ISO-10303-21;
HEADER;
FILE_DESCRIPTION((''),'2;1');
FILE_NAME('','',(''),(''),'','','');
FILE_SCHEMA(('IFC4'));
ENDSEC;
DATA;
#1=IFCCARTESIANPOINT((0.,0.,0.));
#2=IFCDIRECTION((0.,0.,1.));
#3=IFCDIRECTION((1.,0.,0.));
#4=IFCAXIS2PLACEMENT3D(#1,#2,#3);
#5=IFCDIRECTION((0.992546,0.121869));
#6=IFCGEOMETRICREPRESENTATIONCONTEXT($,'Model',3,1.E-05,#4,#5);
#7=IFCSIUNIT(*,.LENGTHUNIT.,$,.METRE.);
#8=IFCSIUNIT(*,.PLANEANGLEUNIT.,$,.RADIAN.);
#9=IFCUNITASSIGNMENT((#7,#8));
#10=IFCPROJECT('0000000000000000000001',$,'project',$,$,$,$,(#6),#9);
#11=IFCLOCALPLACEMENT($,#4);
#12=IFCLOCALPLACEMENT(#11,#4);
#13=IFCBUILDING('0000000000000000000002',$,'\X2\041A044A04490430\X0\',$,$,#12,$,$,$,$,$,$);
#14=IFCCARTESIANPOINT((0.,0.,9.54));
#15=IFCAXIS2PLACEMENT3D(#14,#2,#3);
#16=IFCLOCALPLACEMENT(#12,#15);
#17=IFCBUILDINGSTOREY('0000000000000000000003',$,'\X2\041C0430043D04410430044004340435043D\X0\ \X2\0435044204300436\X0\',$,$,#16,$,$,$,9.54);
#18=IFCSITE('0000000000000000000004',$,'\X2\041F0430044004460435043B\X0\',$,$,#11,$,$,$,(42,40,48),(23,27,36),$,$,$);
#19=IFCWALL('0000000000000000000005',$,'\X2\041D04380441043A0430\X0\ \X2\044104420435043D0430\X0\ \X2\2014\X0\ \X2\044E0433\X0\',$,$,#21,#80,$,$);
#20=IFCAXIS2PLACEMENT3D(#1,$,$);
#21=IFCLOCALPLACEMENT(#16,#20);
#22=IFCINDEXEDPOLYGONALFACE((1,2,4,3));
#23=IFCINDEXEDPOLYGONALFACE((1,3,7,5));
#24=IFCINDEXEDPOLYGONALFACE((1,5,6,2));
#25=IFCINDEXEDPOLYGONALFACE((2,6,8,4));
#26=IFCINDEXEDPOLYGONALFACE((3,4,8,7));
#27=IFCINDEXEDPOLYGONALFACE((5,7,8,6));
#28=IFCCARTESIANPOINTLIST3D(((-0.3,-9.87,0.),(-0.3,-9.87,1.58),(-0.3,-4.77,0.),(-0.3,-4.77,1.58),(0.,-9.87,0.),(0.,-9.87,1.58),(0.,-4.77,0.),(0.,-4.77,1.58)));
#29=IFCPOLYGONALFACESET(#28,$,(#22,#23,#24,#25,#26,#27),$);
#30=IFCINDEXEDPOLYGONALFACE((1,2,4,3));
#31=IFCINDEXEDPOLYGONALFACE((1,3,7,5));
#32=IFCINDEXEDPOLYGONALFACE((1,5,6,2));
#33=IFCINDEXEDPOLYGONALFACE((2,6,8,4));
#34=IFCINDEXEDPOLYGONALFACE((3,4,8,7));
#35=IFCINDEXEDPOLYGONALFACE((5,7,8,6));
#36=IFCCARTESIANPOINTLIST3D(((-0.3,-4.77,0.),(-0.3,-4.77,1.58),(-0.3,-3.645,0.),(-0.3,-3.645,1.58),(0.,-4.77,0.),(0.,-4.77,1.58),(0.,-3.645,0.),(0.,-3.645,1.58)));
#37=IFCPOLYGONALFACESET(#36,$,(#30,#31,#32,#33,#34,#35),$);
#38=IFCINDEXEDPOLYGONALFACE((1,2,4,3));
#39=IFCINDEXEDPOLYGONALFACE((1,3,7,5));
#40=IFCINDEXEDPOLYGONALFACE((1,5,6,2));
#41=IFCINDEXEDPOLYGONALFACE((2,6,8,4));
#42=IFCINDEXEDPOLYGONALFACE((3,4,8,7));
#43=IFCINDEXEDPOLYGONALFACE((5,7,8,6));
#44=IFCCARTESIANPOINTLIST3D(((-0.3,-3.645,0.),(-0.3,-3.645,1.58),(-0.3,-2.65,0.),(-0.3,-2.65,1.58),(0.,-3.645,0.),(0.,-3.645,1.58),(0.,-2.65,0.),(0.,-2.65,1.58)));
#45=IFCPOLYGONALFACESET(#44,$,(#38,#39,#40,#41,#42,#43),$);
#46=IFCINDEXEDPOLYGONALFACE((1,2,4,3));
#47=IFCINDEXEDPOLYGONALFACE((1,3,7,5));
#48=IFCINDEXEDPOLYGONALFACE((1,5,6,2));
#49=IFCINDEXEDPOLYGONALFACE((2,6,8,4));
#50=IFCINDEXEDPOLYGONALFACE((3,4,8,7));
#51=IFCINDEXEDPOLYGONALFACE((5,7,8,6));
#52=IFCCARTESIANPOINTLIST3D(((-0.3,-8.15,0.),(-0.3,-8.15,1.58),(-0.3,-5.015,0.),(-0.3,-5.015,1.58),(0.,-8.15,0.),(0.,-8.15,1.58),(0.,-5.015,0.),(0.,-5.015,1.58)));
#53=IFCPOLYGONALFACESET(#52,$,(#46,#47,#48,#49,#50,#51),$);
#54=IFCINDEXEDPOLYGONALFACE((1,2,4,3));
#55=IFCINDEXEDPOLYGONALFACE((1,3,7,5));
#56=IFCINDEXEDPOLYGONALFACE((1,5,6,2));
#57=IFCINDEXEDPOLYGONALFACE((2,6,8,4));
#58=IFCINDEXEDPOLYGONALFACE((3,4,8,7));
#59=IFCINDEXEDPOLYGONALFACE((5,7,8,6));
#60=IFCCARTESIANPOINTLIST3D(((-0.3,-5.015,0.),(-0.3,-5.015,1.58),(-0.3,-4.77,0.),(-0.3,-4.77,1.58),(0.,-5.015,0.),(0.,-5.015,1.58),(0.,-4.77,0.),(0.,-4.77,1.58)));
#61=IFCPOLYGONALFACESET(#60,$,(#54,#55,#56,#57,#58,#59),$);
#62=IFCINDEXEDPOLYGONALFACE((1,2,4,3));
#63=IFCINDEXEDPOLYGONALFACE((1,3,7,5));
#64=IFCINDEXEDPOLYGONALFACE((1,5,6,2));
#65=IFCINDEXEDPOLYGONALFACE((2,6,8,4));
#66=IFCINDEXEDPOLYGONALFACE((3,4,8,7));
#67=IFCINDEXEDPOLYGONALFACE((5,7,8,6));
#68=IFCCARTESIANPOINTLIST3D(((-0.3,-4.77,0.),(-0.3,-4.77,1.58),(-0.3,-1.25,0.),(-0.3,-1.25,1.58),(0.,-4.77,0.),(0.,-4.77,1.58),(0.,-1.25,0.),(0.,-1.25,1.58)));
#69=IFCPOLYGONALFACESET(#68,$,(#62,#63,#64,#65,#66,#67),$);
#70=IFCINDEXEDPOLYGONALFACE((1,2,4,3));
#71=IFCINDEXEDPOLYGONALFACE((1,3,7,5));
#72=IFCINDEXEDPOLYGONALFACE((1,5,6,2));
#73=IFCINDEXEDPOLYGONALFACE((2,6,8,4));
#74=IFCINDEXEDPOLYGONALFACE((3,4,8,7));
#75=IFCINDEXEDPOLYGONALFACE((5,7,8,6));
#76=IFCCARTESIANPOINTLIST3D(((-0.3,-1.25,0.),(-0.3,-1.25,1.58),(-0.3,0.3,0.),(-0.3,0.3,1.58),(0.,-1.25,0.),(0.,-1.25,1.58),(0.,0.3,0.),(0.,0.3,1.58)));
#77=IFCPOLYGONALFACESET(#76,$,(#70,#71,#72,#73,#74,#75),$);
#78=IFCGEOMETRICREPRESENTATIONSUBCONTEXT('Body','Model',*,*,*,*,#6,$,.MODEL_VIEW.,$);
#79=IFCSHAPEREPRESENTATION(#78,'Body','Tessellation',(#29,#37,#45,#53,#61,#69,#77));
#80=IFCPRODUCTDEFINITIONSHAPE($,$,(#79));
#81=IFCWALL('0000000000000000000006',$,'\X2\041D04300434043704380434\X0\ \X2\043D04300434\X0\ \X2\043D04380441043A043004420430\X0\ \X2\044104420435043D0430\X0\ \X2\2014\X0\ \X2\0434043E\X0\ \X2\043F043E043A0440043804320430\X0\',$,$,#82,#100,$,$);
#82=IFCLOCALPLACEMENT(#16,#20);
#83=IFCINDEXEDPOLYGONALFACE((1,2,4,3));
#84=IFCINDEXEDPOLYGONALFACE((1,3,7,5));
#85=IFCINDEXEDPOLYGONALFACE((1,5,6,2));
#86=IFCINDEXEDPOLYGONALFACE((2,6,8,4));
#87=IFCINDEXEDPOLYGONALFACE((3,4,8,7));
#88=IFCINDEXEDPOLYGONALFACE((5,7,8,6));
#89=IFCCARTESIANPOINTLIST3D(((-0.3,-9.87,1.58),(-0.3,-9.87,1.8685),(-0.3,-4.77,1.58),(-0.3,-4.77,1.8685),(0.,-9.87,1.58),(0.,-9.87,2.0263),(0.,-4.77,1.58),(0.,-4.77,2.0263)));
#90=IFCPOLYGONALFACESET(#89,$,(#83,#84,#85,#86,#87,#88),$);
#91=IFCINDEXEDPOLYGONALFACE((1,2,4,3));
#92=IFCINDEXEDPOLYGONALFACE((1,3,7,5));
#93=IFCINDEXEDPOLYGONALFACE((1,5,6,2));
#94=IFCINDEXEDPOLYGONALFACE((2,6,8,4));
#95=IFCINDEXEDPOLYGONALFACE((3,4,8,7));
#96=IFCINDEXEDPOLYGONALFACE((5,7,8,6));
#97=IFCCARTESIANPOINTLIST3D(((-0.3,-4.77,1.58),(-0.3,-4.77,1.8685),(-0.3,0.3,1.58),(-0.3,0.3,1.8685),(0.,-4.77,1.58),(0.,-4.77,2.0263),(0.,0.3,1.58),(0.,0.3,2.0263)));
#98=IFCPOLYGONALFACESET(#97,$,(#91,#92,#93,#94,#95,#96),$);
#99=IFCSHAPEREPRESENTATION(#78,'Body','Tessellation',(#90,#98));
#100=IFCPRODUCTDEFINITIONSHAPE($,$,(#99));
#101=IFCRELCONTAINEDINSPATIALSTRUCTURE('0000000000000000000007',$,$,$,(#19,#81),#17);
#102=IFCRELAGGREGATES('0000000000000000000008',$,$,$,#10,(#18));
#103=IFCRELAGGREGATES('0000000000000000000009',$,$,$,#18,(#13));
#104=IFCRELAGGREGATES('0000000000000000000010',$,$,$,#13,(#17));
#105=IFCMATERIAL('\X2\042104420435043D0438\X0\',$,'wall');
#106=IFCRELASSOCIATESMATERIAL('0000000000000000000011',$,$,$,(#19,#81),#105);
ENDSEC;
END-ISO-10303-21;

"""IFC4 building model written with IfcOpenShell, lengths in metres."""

from ifc_helpers import new_model, si_unit, direction, frame, origin_with_axes, place, context, subcontext, project, spatial, polyline, outline, extrude, material, element, save


model = new_model("IFC4")

# Units and contexts
model_context = context("Model", 3, precision=1e-05, world=origin_with_axes(), true_north=direction((0.992546, 0.121869)))
body_context = subcontext(model_context, "Body", "Model", "MODEL_VIEW")
ifc_project = project(units=[si_unit("LENGTHUNIT", "METRE"), si_unit("PLANEANGLEUNIT", "RADIAN")], contexts=[model_context])

# Site, building, storey
site_placement = place(None, origin_with_axes())
site = spatial("IfcSite", under=ifc_project, at=site_placement, Name="Парцел", RefLatitude=(42, 40, 48), RefLongitude=(23, 27, 36))
building_placement = place(site_placement, origin_with_axes())
building = spatial("IfcBuilding", under=site, at=building_placement, Name="Къща")
storey_placement = place(building_placement, frame((0.0, 0.0, 9.54), z_axis=(0.0, 0.0, 1.0), x_axis=(1.0, 0.0, 0.0)))
storey = spatial("IfcBuildingStorey", under=building, at=storey_placement, Name="Мансарден етаж", Elevation=9.54)

# Walls
ifc_material_1 = material(Name="Стени", Category="wall")
wall_1_placement = place(storey_placement, origin_with_axes())
element("IfcWall", 1, at=wall_1_placement, inside=storey, material=ifc_material_1, Name="Ниска стена — юг", context=body_context, shape_type="SweptSolid", body=[
    extrude(outline(polyline([(-0.3, 0.0), (0.0, 0.0), (0.0, -1.58), (-0.3, -1.58), (-0.3, 0.0)])), frame((0.0, -9.87, 0.0), z_axis=(0.0, 1.0, 0.0), x_axis=(1.0, 0.0, 0.0)), (0.0, 0.0, 1.0), 5.1),
    extrude(outline(polyline([(-0.3, 0.0), (0.0, 0.0), (0.0, -1.58), (-0.3, -1.58), (-0.3, 0.0)])), frame((0.0, -4.77, 0.0), z_axis=(0.0, 1.0, 0.0), x_axis=(1.0, 0.0, 0.0)), (0.0, 0.0, 1.0), 1.125),
    extrude(outline(polyline([(-0.3, 0.0), (0.0, 0.0), (0.0, -1.58), (-0.3, -1.58), (-0.3, 0.0)])), frame((0.0, -3.645, 0.0), z_axis=(0.0, 1.0, 0.0), x_axis=(1.0, 0.0, 0.0)), (0.0, 0.0, 1.0), 0.995),
    extrude(outline(polyline([(-0.3, 0.0), (0.0, 0.0), (0.0, -1.58), (-0.3, -1.58), (-0.3, 0.0)])), frame((0.0, -8.15, 0.0), z_axis=(0.0, 1.0, 0.0), x_axis=(1.0, 0.0, 0.0)), (0.0, 0.0, 1.0), 3.135),
    extrude(outline(polyline([(-0.3, 0.0), (0.0, 0.0), (0.0, -1.58), (-0.3, -1.58), (-0.3, 0.0)])), frame((0.0, -5.015, 0.0), z_axis=(0.0, 1.0, 0.0), x_axis=(1.0, 0.0, 0.0)), (0.0, 0.0, 1.0), 0.245),
    extrude(outline(polyline([(-0.3, 0.0), (0.0, 0.0), (0.0, -1.58), (-0.3, -1.58), (-0.3, 0.0)])), frame((0.0, -4.77, 0.0), z_axis=(0.0, 1.0, 0.0), x_axis=(1.0, 0.0, 0.0)), (0.0, 0.0, 1.0), 3.52),
    extrude(outline(polyline([(-0.3, 0.0), (0.0, 0.0), (0.0, -1.58), (-0.3, -1.58), (-0.3, 0.0)])), frame((0.0, -1.25, 0.0), z_axis=(0.0, 1.0, 0.0), x_axis=(1.0, 0.0, 0.0)), (0.0, 0.0, 1.0), 1.55),
])
wall_2_placement = place(storey_placement, origin_with_axes())
element("IfcWall", 2, at=wall_2_placement, inside=storey, material=ifc_material_1, Name="Надзид над ниската стена — до покрива", context=body_context, shape_type="SweptSolid", body=[
    extrude(outline(polyline([(-0.3, -1.58), (0.0, -1.58), (0.0, -2.0263), (-0.3, -1.8685), (-0.3, -1.58)])), frame((0.0, -9.87, 0.0), z_axis=(0.0, 1.0, 0.0), x_axis=(1.0, 0.0, 0.0)), (0.0, 0.0, 1.0), 5.1),
    extrude(outline(polyline([(-0.3, -1.58), (0.0, -1.58), (0.0, -2.0263), (-0.3, -1.8685), (-0.3, -1.58)])), frame((0.0, -4.77, 0.0), z_axis=(0.0, 1.0, 0.0), x_axis=(1.0, 0.0, 0.0)), (0.0, 0.0, 1.0), 5.07),
])

save(model, "model.ifc")
